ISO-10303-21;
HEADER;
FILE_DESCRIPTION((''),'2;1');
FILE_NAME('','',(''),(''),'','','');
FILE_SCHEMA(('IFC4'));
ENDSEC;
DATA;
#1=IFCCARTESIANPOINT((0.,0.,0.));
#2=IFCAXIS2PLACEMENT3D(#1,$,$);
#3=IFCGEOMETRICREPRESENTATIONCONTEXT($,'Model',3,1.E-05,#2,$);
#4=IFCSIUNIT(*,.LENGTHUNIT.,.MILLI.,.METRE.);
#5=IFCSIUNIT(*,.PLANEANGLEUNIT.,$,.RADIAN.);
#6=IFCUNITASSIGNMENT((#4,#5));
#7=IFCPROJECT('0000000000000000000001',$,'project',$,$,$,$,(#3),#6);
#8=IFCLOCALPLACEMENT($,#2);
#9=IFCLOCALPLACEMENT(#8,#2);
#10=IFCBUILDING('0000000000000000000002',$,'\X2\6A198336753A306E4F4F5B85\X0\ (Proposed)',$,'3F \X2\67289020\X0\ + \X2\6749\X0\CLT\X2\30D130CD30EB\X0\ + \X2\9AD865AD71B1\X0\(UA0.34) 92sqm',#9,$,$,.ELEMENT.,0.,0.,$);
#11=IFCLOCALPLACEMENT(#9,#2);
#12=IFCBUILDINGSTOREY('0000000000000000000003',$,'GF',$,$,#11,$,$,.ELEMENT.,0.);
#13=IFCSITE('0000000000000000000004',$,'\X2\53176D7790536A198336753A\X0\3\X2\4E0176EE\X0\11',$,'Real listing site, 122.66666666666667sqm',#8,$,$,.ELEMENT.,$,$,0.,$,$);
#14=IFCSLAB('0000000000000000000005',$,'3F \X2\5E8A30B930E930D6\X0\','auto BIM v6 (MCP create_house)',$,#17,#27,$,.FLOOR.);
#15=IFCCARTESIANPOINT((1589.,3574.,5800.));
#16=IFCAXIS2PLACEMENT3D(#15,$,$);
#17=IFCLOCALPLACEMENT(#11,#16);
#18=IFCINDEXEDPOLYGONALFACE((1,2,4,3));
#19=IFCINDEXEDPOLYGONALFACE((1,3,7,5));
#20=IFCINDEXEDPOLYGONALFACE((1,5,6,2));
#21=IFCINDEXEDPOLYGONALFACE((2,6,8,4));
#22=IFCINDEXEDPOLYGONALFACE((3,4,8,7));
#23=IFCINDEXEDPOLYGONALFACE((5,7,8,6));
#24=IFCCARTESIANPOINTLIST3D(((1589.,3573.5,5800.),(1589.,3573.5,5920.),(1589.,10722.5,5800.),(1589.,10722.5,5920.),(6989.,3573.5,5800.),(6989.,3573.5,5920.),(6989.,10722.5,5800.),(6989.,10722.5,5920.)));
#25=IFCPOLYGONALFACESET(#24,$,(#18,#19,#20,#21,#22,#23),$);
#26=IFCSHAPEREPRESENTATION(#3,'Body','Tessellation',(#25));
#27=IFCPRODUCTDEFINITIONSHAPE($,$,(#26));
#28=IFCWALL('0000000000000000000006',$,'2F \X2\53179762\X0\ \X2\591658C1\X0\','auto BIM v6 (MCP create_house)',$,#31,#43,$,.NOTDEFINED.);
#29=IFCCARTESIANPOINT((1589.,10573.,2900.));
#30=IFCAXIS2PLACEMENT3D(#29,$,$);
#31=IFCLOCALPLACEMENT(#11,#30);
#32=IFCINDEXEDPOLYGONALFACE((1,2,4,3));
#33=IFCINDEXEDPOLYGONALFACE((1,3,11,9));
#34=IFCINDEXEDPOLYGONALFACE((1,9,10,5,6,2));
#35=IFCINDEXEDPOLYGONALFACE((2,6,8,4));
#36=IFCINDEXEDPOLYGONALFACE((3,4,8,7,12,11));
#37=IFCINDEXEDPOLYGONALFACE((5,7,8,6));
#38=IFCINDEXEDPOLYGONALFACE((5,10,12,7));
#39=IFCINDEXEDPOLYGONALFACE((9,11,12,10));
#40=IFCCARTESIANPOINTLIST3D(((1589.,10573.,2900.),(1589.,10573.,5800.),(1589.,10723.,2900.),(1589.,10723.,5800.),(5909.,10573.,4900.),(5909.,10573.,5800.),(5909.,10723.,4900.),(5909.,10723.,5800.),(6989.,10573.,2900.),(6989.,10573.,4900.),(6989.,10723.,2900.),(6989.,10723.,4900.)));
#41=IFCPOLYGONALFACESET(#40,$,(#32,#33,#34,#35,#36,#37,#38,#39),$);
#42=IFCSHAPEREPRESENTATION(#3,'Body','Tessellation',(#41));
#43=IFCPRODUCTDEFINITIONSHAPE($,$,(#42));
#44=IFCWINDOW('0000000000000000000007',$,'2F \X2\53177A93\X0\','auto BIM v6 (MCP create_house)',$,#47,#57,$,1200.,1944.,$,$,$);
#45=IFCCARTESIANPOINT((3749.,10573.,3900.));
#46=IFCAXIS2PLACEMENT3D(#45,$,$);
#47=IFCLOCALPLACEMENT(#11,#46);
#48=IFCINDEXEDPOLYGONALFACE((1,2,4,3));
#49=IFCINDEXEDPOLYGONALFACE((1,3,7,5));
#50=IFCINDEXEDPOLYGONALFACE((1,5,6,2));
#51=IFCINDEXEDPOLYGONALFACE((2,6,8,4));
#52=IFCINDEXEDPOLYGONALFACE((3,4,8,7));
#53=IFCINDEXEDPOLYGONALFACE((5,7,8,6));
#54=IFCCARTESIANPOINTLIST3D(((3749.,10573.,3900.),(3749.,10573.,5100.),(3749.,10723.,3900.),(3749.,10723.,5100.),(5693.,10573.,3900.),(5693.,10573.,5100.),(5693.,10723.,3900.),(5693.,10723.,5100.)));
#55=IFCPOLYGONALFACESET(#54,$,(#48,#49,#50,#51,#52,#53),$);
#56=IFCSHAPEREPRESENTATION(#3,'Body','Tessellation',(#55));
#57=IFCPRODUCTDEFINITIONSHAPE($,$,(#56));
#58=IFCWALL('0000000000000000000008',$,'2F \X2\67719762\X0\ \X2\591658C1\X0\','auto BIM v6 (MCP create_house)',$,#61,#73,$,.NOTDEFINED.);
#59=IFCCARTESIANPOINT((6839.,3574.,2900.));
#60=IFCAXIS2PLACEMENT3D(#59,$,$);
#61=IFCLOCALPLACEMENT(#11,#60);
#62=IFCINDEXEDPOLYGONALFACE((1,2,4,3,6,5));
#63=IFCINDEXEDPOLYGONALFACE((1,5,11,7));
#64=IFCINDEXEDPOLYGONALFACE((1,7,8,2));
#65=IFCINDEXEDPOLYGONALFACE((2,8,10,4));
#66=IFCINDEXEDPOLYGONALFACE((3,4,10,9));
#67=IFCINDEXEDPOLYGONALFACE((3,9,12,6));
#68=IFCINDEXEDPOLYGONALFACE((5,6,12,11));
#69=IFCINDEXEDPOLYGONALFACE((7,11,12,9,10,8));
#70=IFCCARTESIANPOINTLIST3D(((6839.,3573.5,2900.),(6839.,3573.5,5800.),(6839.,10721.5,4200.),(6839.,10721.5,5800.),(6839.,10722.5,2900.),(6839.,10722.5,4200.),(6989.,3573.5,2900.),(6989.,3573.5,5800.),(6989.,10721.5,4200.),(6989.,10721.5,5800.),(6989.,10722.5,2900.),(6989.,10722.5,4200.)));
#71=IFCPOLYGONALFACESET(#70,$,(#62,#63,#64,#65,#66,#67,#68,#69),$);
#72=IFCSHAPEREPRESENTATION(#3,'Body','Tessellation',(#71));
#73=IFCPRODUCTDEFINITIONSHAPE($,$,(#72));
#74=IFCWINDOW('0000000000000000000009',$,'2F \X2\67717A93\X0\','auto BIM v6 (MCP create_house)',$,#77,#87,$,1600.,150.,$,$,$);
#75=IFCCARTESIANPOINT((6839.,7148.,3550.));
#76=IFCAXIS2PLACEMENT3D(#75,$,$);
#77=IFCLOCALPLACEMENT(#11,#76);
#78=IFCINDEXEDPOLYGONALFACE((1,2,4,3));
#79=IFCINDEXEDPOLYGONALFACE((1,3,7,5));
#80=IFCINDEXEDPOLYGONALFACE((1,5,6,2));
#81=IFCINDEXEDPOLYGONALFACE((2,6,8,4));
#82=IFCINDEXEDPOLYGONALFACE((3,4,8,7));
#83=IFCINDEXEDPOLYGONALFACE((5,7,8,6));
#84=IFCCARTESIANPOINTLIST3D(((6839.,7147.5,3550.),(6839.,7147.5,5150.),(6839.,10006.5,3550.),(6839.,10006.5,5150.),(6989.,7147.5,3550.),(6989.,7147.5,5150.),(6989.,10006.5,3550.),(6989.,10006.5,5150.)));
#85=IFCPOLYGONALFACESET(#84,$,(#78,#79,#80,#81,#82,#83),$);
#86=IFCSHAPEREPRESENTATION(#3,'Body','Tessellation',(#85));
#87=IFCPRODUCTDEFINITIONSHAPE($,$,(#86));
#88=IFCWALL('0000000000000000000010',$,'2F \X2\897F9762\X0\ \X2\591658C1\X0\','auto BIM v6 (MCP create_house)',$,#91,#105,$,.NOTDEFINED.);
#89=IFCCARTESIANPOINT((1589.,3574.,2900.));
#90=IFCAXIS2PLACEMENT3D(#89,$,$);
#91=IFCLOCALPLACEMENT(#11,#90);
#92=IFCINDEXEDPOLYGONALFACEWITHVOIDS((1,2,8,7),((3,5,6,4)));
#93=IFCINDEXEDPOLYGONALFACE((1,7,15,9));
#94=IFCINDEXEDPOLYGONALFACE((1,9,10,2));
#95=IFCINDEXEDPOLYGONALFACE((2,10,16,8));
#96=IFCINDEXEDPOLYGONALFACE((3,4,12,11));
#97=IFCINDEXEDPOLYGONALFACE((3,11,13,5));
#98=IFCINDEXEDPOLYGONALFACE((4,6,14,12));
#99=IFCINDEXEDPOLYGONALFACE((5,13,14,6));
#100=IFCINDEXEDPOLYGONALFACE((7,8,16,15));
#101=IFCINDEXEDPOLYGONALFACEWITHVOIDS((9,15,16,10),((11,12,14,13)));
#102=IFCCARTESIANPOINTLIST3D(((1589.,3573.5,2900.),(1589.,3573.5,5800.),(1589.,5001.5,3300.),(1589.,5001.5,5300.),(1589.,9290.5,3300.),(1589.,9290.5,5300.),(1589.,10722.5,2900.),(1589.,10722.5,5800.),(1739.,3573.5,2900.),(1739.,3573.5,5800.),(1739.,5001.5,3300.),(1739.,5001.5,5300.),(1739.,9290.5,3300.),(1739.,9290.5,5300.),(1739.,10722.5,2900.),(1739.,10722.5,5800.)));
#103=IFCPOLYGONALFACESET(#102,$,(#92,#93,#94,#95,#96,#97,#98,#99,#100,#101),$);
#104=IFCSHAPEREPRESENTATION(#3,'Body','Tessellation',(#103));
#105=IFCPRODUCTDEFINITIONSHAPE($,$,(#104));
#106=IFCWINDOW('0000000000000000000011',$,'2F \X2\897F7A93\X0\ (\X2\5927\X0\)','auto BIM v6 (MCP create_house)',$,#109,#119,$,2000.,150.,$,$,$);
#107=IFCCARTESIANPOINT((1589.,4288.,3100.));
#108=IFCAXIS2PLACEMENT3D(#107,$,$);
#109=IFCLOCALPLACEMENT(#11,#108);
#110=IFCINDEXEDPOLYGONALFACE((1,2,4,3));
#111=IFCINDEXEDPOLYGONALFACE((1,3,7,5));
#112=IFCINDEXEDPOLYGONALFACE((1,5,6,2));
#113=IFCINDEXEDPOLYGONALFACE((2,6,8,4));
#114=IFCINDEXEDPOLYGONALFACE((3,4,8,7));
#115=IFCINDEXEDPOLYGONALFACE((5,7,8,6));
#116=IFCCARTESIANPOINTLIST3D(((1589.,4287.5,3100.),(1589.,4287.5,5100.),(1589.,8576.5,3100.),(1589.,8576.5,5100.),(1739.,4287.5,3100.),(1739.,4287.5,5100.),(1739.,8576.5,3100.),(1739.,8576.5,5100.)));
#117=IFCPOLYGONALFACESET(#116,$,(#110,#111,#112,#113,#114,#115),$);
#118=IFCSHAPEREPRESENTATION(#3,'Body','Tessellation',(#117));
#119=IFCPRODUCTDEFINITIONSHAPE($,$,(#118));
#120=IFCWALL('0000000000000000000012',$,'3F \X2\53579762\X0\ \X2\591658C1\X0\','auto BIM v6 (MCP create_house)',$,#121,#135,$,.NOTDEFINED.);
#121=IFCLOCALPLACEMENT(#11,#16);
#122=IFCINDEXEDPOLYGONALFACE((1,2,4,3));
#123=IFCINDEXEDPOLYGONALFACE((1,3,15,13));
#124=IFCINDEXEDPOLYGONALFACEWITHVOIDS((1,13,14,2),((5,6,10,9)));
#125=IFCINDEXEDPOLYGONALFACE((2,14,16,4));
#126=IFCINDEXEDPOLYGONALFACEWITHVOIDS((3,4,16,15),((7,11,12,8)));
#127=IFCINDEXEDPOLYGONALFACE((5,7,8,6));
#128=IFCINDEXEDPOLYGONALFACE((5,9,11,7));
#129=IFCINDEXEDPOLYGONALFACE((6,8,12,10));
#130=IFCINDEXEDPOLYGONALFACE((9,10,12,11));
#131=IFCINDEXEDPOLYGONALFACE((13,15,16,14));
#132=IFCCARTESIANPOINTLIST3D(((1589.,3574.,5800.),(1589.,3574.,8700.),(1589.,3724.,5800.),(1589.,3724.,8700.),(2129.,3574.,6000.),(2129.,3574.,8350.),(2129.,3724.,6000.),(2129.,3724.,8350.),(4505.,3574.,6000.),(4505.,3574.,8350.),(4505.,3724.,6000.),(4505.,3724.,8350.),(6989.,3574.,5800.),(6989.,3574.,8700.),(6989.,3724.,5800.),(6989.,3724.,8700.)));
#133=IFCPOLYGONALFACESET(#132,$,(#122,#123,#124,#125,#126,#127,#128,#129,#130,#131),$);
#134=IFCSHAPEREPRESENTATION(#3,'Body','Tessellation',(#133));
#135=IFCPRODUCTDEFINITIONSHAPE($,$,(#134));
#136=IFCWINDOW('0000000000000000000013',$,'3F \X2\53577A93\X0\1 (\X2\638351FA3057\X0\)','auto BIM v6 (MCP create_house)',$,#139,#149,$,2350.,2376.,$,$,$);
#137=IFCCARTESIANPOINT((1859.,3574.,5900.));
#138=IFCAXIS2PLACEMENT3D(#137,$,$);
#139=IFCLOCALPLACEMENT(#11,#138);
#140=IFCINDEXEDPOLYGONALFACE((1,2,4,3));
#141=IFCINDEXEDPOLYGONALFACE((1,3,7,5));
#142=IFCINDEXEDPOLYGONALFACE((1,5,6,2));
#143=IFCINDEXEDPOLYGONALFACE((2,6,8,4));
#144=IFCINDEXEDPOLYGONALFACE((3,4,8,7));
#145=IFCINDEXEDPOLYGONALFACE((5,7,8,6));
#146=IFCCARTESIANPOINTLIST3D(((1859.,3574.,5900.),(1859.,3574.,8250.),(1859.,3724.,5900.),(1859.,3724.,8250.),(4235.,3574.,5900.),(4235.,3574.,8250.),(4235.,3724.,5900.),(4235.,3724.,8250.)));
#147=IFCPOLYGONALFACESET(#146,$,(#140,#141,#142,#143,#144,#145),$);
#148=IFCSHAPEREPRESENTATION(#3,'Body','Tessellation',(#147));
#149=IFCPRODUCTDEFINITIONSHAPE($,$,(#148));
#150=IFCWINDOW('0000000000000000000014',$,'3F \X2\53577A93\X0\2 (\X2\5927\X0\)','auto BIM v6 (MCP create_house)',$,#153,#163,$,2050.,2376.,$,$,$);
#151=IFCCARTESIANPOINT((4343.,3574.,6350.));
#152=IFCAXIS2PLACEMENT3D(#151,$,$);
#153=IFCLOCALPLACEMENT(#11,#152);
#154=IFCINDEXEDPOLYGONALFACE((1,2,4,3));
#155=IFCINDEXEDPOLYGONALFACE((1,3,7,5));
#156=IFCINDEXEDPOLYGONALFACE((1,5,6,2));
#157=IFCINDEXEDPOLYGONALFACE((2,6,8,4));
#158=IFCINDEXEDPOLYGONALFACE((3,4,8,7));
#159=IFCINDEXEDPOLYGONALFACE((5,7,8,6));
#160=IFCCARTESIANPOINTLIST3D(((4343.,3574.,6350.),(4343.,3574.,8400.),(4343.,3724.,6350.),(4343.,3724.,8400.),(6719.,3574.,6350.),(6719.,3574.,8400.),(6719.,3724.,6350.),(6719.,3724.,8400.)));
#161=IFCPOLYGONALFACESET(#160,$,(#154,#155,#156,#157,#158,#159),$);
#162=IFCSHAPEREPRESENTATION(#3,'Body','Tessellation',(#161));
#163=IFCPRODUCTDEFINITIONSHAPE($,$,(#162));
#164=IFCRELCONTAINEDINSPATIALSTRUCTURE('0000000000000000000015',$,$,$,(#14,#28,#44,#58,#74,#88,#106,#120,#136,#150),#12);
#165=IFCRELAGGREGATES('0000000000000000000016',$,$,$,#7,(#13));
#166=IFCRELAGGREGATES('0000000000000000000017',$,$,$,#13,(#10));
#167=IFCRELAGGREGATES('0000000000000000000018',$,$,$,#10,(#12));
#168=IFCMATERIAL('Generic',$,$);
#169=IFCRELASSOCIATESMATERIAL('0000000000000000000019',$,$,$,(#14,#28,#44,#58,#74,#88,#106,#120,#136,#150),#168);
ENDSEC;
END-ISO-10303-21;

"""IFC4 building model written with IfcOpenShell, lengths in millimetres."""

from ifc_helpers import new_model, si_unit, frame, frame_2d, origin, place, context, project, spatial, rectangle, extrude, material, element, fill, save


model = new_model("IFC4")

# Units and contexts
model_context = context("Model", 3, precision=1e-05, world=origin())
ifc_project = project(units=[si_unit("LENGTHUNIT", "METRE", prefix="MILLI"), si_unit("PLANEANGLEUNIT", "RADIAN")], contexts=[model_context])

# Site, building, storey
site_placement = place(None, origin())
site = spatial("IfcSite", under=ifc_project, at=site_placement, Name="北海道標茶町3丁目11", ObjectType="Real listing site, 122.66666666666667sqm", CompositionType="ELEMENT", RefElevation=0.0)
building_placement = place(site_placement, origin())
building = spatial("IfcBuilding", under=site, at=building_placement, Name="標茶町の住宅 (Proposed)", ObjectType="3F 木造 + 杉CLTパネル + 高断熱(UA0.34) 92sqm", CompositionType="ELEMENT", ElevationOfRefHeight=0.0, ElevationOfTerrain=0.0)
storey_placement = place(building_placement, origin())
storey = spatial("IfcBuildingStorey", under=building, at=storey_placement, Name="GF", CompositionType="ELEMENT", Elevation=0.0)

# Slab
ifc_material = material(Name="Generic")
slab_placement = place(storey_placement, frame((1589.0, 3574.0, 5800.0)))
element("IfcSlab", 1, at=slab_placement, inside=storey, material=ifc_material, Name="3F 床スラブ", Description="auto BIM v6 (MCP create_house)", PredefinedType="FLOOR", context=model_context, shape_type="SweptSolid", body=[
    extrude(rectangle(XDim=5400.0, YDim=7149.0, at=frame_2d((2700.0, 3574.0))), frame((1589.0, 3574.0, 5800.0)), (0.0, 0.0, 1.0), 120.0),
])

# Walls, openings, windows
wall_1_placement = place(storey_placement, frame((1589.0, 10573.0, 2900.0)))
wall_1 = element("IfcWall", 2, at=wall_1_placement, inside=storey, material=ifc_material, Name="2F 北面 外壁", Description="auto BIM v6 (MCP create_house)", PredefinedType="NOTDEFINED", context=model_context, shape_type="SweptSolid", body=[
    extrude(rectangle(XDim=5400.0, YDim=150.0, at=frame_2d((2700.0, 75.0))), frame((1589.0, 10573.0, 2900.0)), (0.0, 0.0, 1.0), 2900.0),
])
opening_1_placement = place(storey_placement, frame((3749.0, 10573.0, 3900.0)))
opening_1 = element("IfcOpeningElement", 3, at=opening_1_placement, cuts=wall_1, PredefinedType="NOTDEFINED", context=model_context, shape_type="SweptSolid", body=[
    extrude(rectangle(XDim=1944.0, YDim=150.0, at=frame_2d((972.0, 75.0))), frame((3749.0, 10573.0, 3900.0)), (0.0, 0.0, 1.0), 1200.0),
])
window_1_placement = place(storey_placement, frame((3749.0, 10573.0, 3900.0)))
window_1 = element("IfcWindow", 4, at=window_1_placement, inside=storey, material=ifc_material, Name="2F 北窓", Description="auto BIM v6 (MCP create_house)", OverallHeight=1200.0, OverallWidth=1944.0, context=model_context, shape_type="SweptSolid", body=[
    extrude(rectangle(XDim=1944.0, YDim=150.0, at=frame_2d((972.0, 75.0))), frame((3749.0, 10573.0, 3900.0)), (0.0, 0.0, 1.0), 1200.0),
])
fill(opening_1, window_1)
wall_2_placement = place(storey_placement, frame((6839.0, 3574.0, 2900.0)))
wall_2 = element("IfcWall", 5, at=wall_2_placement, inside=storey, material=ifc_material, Name="2F 東面 外壁", Description="auto BIM v6 (MCP create_house)", PredefinedType="NOTDEFINED", context=model_context, shape_type="SweptSolid", body=[
    extrude(rectangle(XDim=150.0, YDim=7149.0, at=frame_2d((75.0, 3574.0))), frame((6839.0, 3574.0, 2900.0)), (0.0, 0.0, 1.0), 2900.0),
])
opening_2_placement = place(storey_placement, frame((6839.0, 7148.0, 3550.0)))
opening_2 = element("IfcOpeningElement", 6, at=opening_2_placement, cuts=wall_2, PredefinedType="NOTDEFINED", context=model_context, shape_type="SweptSolid", body=[
    extrude(rectangle(XDim=150.0, YDim=2859.0, at=frame_2d((75.0, 1429.0))), frame((6839.0, 7148.0, 3550.0)), (0.0, 0.0, 1.0), 1600.0),
])
window_2_placement = place(storey_placement, frame((6839.0, 7148.0, 3550.0)))
window_2 = element("IfcWindow", 7, at=window_2_placement, inside=storey, material=ifc_material, Name="2F 東窓", Description="auto BIM v6 (MCP create_house)", OverallHeight=1600.0, OverallWidth=150.0, context=model_context, shape_type="SweptSolid", body=[
    extrude(rectangle(XDim=150.0, YDim=2859.0, at=frame_2d((75.0, 1429.0))), frame((6839.0, 7148.0, 3550.0)), (0.0, 0.0, 1.0), 1600.0),
])
fill(opening_2, window_2)
wall_3_placement = place(storey_placement, frame((1589.0, 3574.0, 2900.0)))
wall_3 = element("IfcWall", 8, at=wall_3_placement, inside=storey, material=ifc_material, Name="2F 西面 外壁", Description="auto BIM v6 (MCP create_house)", PredefinedType="NOTDEFINED", context=model_context, shape_type="SweptSolid", body=[
    extrude(rectangle(XDim=150.0, YDim=7149.0, at=frame_2d((75.0, 3574.0))), frame((1589.0, 3574.0, 2900.0)), (0.0, 0.0, 1.0), 2900.0),
])
opening_3_placement = place(storey_placement, frame((1589.0, 4288.0, 3100.0)))
opening_3 = element("IfcOpeningElement", 9, at=opening_3_placement, cuts=wall_3, PredefinedType="NOTDEFINED", context=model_context, shape_type="SweptSolid", body=[
    extrude(rectangle(XDim=150.0, YDim=4289.0, at=frame_2d((75.0, 2144.0))), frame((1589.0, 4288.0, 3100.0)), (0.0, 0.0, 1.0), 2000.0),
])
window_3_placement = place(storey_placement, frame((1589.0, 4288.0, 3100.0)))
window_3 = element("IfcWindow", 10, at=window_3_placement, inside=storey, material=ifc_material, Name="2F 西窓 (大)", Description="auto BIM v6 (MCP create_house)", OverallHeight=2000.0, OverallWidth=150.0, context=model_context, shape_type="SweptSolid", body=[
    extrude(rectangle(XDim=150.0, YDim=4289.0, at=frame_2d((75.0, 2144.0))), frame((1589.0, 4288.0, 3100.0)), (0.0, 0.0, 1.0), 2000.0),
])
fill(opening_3, window_3)

# Wall, openings, windows
wall_4_placement = place(storey_placement, frame((1589.0, 3574.0, 5800.0)))
wall_4 = element("IfcWall", 11, at=wall_4_placement, inside=storey, material=ifc_material, Name="3F 南面 外壁", Description="auto BIM v6 (MCP create_house)", PredefinedType="NOTDEFINED", context=model_context, shape_type="SweptSolid", body=[
    extrude(rectangle(XDim=5400.0, YDim=150.0, at=frame_2d((2700.0, 75.0))), frame((1589.0, 3574.0, 5800.0)), (0.0, 0.0, 1.0), 2900.0),
])
opening_4_placement = place(storey_placement, frame((1859.0, 3574.0, 5900.0)))
opening_4 = element("IfcOpeningElement", 12, at=opening_4_placement, cuts=wall_4, PredefinedType="NOTDEFINED", context=model_context, shape_type="SweptSolid", body=[
    extrude(rectangle(XDim=2376.0, YDim=150.0, at=frame_2d((1188.0, 75.0))), frame((1859.0, 3574.0, 5900.0)), (0.0, 0.0, 1.0), 2350.0),
])
opening_5_placement = place(storey_placement, frame((4343.0, 3574.0, 6350.0)))
opening_5 = element("IfcOpeningElement", 13, at=opening_5_placement, cuts=wall_4, PredefinedType="NOTDEFINED", context=model_context, shape_type="SweptSolid", body=[
    extrude(rectangle(XDim=2376.0, YDim=150.0, at=frame_2d((1188.0, 75.0))), frame((4343.0, 3574.0, 6350.0)), (0.0, 0.0, 1.0), 2050.0),
])
window_4_placement = place(storey_placement, frame((1859.0, 3574.0, 5900.0)))
window_4 = element("IfcWindow", 14, at=window_4_placement, inside=storey, material=ifc_material, Name="3F 南窓1 (掃出し)", Description="auto BIM v6 (MCP create_house)", OverallHeight=2350.0, OverallWidth=2376.0, context=model_context, shape_type="SweptSolid", body=[
    extrude(rectangle(XDim=2376.0, YDim=150.0, at=frame_2d((1188.0, 75.0))), frame((1859.0, 3574.0, 5900.0)), (0.0, 0.0, 1.0), 2350.0),
])
fill(opening_4, window_4)
window_5_placement = place(storey_placement, frame((4343.0, 3574.0, 6350.0)))
window_5 = element("IfcWindow", 15, at=window_5_placement, inside=storey, material=ifc_material, Name="3F 南窓2 (大)", Description="auto BIM v6 (MCP create_house)", OverallHeight=2050.0, OverallWidth=2376.0, context=model_context, shape_type="SweptSolid", body=[
    extrude(rectangle(XDim=2376.0, YDim=150.0, at=frame_2d((1188.0, 75.0))), frame((4343.0, 3574.0, 6350.0)), (0.0, 0.0, 1.0), 2050.0),
])
fill(opening_5, window_5)

save(model, "model.ifc")
